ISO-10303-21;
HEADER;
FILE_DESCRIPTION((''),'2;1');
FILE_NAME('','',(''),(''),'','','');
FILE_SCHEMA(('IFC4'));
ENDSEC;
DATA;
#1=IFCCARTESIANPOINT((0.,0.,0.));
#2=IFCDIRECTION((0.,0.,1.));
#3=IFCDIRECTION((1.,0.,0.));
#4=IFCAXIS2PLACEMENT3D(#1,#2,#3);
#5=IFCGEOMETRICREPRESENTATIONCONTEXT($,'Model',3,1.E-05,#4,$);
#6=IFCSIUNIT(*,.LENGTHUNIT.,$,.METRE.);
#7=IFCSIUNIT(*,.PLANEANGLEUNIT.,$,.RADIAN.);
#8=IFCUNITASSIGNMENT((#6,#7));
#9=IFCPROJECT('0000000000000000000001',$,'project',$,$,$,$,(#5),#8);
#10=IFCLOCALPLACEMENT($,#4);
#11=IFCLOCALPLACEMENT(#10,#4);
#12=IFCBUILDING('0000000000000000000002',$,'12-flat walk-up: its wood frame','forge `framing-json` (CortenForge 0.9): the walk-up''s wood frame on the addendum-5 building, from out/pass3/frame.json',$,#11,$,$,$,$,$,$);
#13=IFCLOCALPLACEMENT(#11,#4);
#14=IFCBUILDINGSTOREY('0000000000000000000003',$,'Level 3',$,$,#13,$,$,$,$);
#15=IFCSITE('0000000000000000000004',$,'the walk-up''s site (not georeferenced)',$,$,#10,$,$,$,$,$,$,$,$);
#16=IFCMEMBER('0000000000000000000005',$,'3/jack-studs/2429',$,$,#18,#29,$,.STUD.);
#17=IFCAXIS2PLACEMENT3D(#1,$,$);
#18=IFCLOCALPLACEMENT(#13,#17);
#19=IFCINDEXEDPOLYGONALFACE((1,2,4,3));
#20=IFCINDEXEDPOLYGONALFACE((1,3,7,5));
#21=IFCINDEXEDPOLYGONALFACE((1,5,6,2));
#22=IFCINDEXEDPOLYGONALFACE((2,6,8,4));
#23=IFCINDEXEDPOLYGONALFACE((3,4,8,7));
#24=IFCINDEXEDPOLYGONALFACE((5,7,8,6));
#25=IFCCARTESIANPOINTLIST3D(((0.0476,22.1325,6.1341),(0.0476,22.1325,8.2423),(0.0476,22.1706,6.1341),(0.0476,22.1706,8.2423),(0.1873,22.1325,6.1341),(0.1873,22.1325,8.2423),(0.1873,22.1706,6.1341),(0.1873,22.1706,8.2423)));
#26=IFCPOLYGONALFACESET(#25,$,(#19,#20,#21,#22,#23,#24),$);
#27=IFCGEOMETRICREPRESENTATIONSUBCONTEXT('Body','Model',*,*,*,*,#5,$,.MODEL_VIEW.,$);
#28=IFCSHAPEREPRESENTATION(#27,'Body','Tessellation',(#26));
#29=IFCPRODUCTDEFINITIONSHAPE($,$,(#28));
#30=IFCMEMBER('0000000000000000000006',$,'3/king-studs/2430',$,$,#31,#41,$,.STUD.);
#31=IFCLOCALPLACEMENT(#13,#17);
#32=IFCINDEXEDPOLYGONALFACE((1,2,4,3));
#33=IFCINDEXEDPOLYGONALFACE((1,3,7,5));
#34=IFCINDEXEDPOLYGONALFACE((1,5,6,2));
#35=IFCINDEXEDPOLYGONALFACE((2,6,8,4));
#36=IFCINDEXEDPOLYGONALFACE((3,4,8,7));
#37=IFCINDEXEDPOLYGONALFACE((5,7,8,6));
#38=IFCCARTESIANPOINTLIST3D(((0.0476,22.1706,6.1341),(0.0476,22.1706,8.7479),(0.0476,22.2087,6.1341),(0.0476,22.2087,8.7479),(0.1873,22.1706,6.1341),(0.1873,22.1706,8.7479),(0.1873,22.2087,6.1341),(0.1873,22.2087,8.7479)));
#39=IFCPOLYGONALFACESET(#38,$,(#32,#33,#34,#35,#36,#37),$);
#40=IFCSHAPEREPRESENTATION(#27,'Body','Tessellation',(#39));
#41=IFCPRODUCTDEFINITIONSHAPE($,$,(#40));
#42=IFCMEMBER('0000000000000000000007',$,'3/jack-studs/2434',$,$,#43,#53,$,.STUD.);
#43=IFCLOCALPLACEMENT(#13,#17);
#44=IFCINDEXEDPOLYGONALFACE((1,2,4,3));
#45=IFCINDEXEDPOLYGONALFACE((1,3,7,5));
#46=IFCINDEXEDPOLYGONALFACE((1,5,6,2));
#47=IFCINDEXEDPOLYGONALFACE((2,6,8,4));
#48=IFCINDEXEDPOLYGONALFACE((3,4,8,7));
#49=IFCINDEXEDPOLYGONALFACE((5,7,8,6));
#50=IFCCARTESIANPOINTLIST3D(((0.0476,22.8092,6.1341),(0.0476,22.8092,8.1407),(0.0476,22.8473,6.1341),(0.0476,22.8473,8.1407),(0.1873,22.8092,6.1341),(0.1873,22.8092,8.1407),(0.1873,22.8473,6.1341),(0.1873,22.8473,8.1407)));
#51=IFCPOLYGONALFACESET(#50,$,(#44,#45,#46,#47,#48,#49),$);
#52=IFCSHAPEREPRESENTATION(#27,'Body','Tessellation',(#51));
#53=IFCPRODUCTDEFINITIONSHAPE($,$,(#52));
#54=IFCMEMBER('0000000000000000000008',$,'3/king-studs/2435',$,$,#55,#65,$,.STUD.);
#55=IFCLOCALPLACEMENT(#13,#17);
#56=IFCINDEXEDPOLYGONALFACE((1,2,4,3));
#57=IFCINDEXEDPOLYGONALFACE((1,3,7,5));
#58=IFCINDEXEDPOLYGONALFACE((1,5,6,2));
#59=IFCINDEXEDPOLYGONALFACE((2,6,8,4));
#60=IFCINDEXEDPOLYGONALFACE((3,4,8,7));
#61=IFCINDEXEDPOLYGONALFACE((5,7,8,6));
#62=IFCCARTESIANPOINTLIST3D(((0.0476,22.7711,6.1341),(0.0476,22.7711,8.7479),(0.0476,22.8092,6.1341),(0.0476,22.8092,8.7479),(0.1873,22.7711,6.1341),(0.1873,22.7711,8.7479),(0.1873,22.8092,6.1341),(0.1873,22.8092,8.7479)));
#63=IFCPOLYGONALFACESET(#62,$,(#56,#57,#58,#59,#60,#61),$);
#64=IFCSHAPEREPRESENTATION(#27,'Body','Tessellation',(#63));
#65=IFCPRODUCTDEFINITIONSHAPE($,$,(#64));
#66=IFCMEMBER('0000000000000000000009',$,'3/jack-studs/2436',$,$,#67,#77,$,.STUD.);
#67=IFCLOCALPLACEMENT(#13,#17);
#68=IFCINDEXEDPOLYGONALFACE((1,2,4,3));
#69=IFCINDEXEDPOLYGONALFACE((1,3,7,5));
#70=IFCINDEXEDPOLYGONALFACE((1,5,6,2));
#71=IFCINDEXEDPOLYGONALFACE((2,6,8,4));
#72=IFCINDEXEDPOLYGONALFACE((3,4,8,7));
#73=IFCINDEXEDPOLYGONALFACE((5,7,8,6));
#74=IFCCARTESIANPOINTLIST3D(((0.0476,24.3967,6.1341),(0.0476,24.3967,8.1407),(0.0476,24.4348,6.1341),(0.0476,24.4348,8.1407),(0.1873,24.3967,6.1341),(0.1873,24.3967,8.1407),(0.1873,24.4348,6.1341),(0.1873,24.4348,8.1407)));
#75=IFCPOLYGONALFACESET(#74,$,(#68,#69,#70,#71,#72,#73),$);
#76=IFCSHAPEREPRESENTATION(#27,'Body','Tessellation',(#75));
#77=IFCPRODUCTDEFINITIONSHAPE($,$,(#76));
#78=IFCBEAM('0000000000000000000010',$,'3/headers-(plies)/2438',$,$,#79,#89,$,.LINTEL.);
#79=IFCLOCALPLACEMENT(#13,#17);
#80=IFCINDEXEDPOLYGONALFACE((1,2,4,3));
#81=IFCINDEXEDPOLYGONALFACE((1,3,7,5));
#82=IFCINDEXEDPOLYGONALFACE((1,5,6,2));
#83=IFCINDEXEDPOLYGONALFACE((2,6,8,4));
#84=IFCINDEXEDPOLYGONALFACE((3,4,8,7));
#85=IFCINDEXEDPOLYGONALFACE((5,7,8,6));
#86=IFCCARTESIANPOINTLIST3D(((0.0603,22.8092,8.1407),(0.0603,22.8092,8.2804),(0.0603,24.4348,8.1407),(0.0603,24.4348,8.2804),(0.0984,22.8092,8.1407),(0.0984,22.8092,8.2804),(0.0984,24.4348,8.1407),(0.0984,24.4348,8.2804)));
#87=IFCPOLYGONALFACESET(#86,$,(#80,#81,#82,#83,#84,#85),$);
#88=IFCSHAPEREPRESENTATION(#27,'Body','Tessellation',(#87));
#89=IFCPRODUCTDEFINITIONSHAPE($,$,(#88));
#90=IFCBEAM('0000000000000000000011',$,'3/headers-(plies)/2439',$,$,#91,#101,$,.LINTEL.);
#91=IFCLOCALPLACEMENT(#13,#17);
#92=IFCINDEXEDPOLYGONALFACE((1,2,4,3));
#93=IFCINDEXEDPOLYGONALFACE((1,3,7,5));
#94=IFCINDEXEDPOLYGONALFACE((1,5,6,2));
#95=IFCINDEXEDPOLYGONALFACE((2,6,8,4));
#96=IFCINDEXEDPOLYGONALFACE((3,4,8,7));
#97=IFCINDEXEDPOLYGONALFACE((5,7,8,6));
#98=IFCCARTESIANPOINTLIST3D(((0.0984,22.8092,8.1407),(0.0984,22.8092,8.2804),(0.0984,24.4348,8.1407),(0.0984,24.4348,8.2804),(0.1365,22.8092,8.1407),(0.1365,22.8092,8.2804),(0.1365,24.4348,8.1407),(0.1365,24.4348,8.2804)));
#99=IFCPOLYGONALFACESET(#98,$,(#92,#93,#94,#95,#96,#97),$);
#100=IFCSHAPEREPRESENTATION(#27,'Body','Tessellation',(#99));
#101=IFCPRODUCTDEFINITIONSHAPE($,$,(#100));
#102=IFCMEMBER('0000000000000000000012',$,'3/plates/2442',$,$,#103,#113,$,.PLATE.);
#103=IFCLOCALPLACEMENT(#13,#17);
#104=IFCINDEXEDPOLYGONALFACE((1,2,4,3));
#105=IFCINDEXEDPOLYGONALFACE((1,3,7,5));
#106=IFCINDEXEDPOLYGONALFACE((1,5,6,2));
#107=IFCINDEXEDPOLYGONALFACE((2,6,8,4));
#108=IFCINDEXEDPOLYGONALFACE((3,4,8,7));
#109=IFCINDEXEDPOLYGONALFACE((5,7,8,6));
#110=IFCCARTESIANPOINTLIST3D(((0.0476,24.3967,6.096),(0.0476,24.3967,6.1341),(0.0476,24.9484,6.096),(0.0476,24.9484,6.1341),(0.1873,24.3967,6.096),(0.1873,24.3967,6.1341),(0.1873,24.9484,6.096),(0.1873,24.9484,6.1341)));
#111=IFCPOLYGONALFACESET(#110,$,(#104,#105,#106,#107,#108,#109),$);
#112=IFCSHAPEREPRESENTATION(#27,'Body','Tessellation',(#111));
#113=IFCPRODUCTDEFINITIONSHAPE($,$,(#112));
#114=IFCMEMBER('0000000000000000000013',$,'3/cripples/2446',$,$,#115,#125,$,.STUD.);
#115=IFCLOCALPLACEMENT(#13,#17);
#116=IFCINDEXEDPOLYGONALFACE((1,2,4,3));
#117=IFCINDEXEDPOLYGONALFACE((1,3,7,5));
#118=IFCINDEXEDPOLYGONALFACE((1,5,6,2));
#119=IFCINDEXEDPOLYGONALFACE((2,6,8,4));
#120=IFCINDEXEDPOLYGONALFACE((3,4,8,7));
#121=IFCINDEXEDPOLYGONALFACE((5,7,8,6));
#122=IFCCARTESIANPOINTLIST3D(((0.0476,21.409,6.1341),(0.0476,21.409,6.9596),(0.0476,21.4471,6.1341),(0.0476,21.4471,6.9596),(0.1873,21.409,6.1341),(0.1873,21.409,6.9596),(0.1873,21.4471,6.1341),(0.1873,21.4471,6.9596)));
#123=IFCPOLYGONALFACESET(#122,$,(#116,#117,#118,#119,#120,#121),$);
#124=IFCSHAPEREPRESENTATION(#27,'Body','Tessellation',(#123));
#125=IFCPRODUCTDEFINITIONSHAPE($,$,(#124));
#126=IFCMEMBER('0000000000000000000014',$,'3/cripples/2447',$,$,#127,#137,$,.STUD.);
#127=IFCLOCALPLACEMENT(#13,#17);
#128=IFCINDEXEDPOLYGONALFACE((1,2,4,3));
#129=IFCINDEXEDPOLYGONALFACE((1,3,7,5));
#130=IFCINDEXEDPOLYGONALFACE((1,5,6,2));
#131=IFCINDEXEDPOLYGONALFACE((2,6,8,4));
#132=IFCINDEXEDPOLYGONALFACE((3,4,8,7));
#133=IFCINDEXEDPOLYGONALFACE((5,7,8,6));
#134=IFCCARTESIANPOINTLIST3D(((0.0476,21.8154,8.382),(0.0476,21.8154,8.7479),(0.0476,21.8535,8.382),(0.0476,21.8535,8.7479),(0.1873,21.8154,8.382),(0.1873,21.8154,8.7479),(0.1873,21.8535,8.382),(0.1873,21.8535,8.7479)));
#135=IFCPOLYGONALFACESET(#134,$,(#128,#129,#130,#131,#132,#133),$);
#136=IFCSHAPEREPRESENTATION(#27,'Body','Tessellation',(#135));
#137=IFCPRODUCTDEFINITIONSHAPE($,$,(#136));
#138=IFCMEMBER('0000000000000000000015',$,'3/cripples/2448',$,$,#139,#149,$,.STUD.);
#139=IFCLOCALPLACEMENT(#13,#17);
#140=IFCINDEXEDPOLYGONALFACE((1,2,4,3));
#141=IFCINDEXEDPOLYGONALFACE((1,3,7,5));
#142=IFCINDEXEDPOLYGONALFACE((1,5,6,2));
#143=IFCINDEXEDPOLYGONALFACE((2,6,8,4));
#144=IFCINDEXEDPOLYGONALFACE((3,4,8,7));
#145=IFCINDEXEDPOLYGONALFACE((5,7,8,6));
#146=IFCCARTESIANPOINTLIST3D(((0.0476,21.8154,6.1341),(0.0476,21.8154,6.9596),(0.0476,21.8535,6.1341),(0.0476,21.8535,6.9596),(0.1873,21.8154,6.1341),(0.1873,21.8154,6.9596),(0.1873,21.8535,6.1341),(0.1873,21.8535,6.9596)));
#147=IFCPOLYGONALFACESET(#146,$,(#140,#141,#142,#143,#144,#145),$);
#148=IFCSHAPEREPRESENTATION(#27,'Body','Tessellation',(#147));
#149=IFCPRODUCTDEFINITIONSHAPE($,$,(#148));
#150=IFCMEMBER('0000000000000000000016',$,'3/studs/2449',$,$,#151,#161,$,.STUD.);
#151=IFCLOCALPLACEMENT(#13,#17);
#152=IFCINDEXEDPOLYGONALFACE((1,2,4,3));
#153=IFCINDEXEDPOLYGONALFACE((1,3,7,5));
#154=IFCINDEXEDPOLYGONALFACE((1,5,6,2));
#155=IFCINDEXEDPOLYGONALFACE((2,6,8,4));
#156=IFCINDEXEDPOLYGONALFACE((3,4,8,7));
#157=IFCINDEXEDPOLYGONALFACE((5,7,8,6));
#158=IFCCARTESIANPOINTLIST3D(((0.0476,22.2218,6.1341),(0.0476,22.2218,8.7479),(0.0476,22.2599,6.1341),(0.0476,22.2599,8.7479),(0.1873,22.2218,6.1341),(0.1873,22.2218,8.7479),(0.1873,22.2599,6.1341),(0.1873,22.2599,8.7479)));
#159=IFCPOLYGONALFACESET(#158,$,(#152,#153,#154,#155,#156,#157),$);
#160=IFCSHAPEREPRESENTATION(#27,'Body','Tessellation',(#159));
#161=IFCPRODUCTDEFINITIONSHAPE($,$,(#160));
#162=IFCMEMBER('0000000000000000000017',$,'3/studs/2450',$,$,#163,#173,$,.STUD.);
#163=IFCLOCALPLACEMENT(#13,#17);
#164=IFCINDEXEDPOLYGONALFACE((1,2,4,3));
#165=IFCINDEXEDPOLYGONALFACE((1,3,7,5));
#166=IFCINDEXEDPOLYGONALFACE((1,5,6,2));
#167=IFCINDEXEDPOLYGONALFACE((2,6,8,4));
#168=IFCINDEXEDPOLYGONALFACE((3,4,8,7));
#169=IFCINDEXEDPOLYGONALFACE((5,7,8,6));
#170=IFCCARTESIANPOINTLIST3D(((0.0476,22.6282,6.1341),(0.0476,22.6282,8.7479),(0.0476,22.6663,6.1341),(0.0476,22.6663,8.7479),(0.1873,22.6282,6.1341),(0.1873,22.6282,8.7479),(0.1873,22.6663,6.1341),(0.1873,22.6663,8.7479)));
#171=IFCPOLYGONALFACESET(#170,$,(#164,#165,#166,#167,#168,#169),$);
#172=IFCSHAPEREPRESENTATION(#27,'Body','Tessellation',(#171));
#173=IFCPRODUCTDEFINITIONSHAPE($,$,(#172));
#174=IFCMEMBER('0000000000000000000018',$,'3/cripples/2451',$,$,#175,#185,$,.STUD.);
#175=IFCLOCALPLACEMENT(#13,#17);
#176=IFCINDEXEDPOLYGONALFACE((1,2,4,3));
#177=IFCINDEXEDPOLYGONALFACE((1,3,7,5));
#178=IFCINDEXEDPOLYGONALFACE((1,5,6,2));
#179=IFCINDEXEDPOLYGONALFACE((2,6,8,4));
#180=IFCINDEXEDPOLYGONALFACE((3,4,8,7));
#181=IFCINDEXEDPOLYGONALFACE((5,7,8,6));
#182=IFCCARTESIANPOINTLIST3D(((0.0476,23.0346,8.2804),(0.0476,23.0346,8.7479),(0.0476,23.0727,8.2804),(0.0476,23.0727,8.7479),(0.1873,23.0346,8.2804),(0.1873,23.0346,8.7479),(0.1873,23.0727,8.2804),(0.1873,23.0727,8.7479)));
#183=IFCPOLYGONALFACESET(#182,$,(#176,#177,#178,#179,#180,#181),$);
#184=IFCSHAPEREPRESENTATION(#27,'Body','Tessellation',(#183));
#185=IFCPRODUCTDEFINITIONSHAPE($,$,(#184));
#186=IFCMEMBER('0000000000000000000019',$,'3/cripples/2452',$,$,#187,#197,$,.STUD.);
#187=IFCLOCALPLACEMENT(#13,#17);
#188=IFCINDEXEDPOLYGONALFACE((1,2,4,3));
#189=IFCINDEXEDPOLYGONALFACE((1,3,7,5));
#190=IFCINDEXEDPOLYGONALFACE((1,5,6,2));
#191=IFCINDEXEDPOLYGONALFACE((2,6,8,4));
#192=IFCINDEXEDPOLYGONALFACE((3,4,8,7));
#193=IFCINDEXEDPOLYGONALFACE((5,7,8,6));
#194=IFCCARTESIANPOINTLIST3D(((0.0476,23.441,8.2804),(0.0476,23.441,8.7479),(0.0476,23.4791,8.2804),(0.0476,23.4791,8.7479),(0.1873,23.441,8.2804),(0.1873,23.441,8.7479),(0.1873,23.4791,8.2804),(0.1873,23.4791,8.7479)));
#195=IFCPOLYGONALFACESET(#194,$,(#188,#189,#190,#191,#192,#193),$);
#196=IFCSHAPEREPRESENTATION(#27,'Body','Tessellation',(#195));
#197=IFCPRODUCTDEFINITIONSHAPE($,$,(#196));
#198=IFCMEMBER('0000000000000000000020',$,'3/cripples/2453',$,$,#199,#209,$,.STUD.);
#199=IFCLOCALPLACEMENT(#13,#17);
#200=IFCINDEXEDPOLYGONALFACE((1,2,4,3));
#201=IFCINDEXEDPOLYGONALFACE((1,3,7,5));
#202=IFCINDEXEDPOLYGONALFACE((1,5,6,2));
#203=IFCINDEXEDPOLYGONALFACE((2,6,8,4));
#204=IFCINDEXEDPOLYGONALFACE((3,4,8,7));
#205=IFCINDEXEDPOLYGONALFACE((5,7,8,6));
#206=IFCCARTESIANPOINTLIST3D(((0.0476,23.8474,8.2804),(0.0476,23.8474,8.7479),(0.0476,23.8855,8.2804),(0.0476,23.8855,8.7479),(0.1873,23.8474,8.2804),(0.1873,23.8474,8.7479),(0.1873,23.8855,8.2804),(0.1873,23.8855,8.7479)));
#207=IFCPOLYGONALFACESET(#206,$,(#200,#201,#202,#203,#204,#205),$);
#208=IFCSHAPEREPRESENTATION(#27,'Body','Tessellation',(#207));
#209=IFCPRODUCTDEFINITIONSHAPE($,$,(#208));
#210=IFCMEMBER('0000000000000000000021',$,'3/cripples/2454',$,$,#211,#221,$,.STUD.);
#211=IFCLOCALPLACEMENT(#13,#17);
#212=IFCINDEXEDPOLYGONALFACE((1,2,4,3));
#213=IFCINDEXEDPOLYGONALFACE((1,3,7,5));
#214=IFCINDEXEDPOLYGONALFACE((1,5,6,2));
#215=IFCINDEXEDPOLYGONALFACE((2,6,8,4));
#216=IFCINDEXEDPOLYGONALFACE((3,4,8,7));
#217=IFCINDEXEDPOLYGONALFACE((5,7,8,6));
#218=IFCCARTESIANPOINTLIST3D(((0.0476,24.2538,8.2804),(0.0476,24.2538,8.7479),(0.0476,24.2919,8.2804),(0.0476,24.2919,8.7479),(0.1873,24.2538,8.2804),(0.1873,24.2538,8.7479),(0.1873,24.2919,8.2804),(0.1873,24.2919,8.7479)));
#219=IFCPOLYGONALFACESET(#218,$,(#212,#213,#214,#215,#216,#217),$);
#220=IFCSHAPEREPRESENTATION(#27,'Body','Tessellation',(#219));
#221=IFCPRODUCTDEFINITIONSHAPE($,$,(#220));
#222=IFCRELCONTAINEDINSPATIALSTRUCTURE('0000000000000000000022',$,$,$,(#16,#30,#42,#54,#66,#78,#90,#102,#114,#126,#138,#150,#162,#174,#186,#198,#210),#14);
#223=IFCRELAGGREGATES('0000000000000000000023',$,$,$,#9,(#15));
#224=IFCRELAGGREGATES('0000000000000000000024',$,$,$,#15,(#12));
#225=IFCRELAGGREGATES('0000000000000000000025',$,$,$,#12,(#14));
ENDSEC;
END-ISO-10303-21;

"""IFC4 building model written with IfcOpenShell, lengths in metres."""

from ifc_helpers import new_model, si_unit, frame, frame_2d, origin, origin_with_axes, place, context, subcontext, project, spatial, rectangle, extrude, element, save


model = new_model("IFC4")

# Units and contexts
model_context = context("Model", 3, precision=1e-05, world=origin_with_axes())
body_context = subcontext(model_context, "Body", "Model", "MODEL_VIEW")
ifc_project = project(units=[si_unit("LENGTHUNIT", "METRE"), si_unit("PLANEANGLEUNIT", "RADIAN")], contexts=[model_context])

# Site, building, storey
site_placement = place(None, origin_with_axes())
site = spatial("IfcSite", under=ifc_project, at=site_placement, Name="the walk-up's site (not georeferenced)")
building_placement = place(site_placement, origin_with_axes())
building = spatial("IfcBuilding", under=site, at=building_placement, Name="12-flat walk-up: its wood frame", Description="forge `framing-json` (CortenForge 0.9): the walk-up's wood frame on the addendum-5 building, from out/pass3/frame.json")
storey_placement = place(building_placement, origin_with_axes())
storey = spatial("IfcBuildingStorey", under=building, at=storey_placement, Name="Level 3")

# Members
member_1_placement = place(storey_placement, frame((0.0476, 22.1325, 6.1341), z_axis=(0.0, 0.0, 1.0), x_axis=(1.0, 0.0, 0.0)))
element("IfcMember", 1, at=member_1_placement, inside=storey, Name="3/jack-studs/2429", PredefinedType="STUD", context=body_context, shape_type="SweptSolid", body=[
    extrude(rectangle(XDim=0.1397, YDim=0.0381, at=frame_2d((0.0698, 0.0191))), origin(), (0.0, 0.0, 1.0), 2.1082),
])
member_2_placement = place(storey_placement, frame((0.0476, 22.1706, 6.1341), z_axis=(0.0, 0.0, 1.0), x_axis=(1.0, 0.0, 0.0)))
element("IfcMember", 2, at=member_2_placement, inside=storey, Name="3/king-studs/2430", PredefinedType="STUD", context=body_context, shape_type="SweptSolid", body=[
    extrude(rectangle(XDim=0.1397, YDim=0.0381, at=frame_2d((0.0698, 0.0191))), origin(), (0.0, 0.0, 1.0), 2.6138),
])
member_3_placement = place(storey_placement, frame((0.0476, 22.8092, 6.1341), z_axis=(0.0, 0.0, 1.0), x_axis=(1.0, 0.0, 0.0)))
element("IfcMember", 3, at=member_3_placement, inside=storey, Name="3/jack-studs/2434", PredefinedType="STUD", context=body_context, shape_type="SweptSolid", body=[
    extrude(rectangle(XDim=0.1397, YDim=0.0381, at=frame_2d((0.0698, 0.0191))), origin(), (0.0, 0.0, 1.0), 2.0066),
])
member_4_placement = place(storey_placement, frame((0.0476, 22.7711, 6.1341), z_axis=(0.0, 0.0, 1.0), x_axis=(1.0, 0.0, 0.0)))
element("IfcMember", 4, at=member_4_placement, inside=storey, Name="3/king-studs/2435", PredefinedType="STUD", context=body_context, shape_type="SweptSolid", body=[
    extrude(rectangle(XDim=0.1397, YDim=0.0381, at=frame_2d((0.0698, 0.0191))), origin(), (0.0, 0.0, 1.0), 2.6138),
])
member_5_placement = place(storey_placement, frame((0.0476, 24.3967, 6.1341), z_axis=(0.0, 0.0, 1.0), x_axis=(1.0, 0.0, 0.0)))
element("IfcMember", 5, at=member_5_placement, inside=storey, Name="3/jack-studs/2436", PredefinedType="STUD", context=body_context, shape_type="SweptSolid", body=[
    extrude(rectangle(XDim=0.1397, YDim=0.0381, at=frame_2d((0.0698, 0.0191))), origin(), (0.0, 0.0, 1.0), 2.0066),
])

# Beams
beam_1_placement = place(storey_placement, frame((0.0603, 22.8092, 8.1407), z_axis=(0.0, 0.0, 1.0), x_axis=(1.0, 0.0, 0.0)))
element("IfcBeam", 6, at=beam_1_placement, inside=storey, Name="3/headers-(plies)/2438", PredefinedType="LINTEL", context=body_context, shape_type="SweptSolid", body=[
    extrude(rectangle(XDim=0.0381, YDim=1.6256, at=frame_2d((0.0191, 0.8128))), origin(), (0.0, 0.0, 1.0), 0.1397),
])
beam_2_placement = place(storey_placement, frame((0.0984, 22.8092, 8.1407), z_axis=(0.0, 0.0, 1.0), x_axis=(1.0, 0.0, 0.0)))
element("IfcBeam", 7, at=beam_2_placement, inside=storey, Name="3/headers-(plies)/2439", PredefinedType="LINTEL", context=body_context, shape_type="SweptSolid", body=[
    extrude(rectangle(XDim=0.0381, YDim=1.6256, at=frame_2d((0.0191, 0.8128))), origin(), (0.0, 0.0, 1.0), 0.1397),
])

# Members
member_6_placement = place(storey_placement, frame((0.0476, 24.3967, 6.096), z_axis=(0.0, 0.0, 1.0), x_axis=(1.0, 0.0, 0.0)))
element("IfcMember", 8, at=member_6_placement, inside=storey, Name="3/plates/2442", PredefinedType="PLATE", context=body_context, shape_type="SweptSolid", body=[
    extrude(rectangle(XDim=0.1397, YDim=0.5517, at=frame_2d((0.0698, 0.2759))), origin(), (0.0, 0.0, 1.0), 0.0381),
])
member_7_placement = place(storey_placement, frame((0.0476, 21.409, 6.1341), z_axis=(0.0, 0.0, 1.0), x_axis=(1.0, 0.0, 0.0)))
element("IfcMember", 9, at=member_7_placement, inside=storey, Name="3/cripples/2446", PredefinedType="STUD", context=body_context, shape_type="SweptSolid", body=[
    extrude(rectangle(XDim=0.1397, YDim=0.0381, at=frame_2d((0.0698, 0.0191))), origin(), (0.0, 0.0, 1.0), 0.8255),
])
member_8_placement = place(storey_placement, frame((0.0476, 21.8154, 8.382), z_axis=(0.0, 0.0, 1.0), x_axis=(1.0, 0.0, 0.0)))
element("IfcMember", 10, at=member_8_placement, inside=storey, Name="3/cripples/2447", PredefinedType="STUD", context=body_context, shape_type="SweptSolid", body=[
    extrude(rectangle(XDim=0.1397, YDim=0.0381, at=frame_2d((0.0698, 0.0191))), origin(), (0.0, 0.0, 1.0), 0.3659),
])
member_9_placement = place(storey_placement, frame((0.0476, 21.8154, 6.1341), z_axis=(0.0, 0.0, 1.0), x_axis=(1.0, 0.0, 0.0)))
element("IfcMember", 11, at=member_9_placement, inside=storey, Name="3/cripples/2448", PredefinedType="STUD", context=body_context, shape_type="SweptSolid", body=[
    extrude(rectangle(XDim=0.1397, YDim=0.0381, at=frame_2d((0.0698, 0.0191))), origin(), (0.0, 0.0, 1.0), 0.8255),
])
for number, where, z_axis, x_axis, name in (
    (12, (0.0476, 22.2218, 6.1341), (0.0, 0.0, 1.0), (1.0, 0.0, 0.0), "3/studs/2449"),
    (13, (0.0476, 22.6282, 6.1341), (0.0, 0.0, 1.0), (1.0, 0.0, 0.0), "3/studs/2450"),
):
    element("IfcMember", number, at=place(storey_placement, frame(where, z_axis=z_axis, x_axis=x_axis)), inside=storey, Name=name, PredefinedType="STUD", context=body_context, shape_type="SweptSolid", body=[
        extrude(rectangle(XDim=0.1397, YDim=0.0381, at=frame_2d((0.0698, 0.0191))), origin(), (0.0, 0.0, 1.0), 2.6138),
    ])
for number, where, z_axis, x_axis, name in (
    (14, (0.0476, 23.0346, 8.2804), (0.0, 0.0, 1.0), (1.0, 0.0, 0.0), "3/cripples/2451"),
    (15, (0.0476, 23.441, 8.2804), (0.0, 0.0, 1.0), (1.0, 0.0, 0.0), "3/cripples/2452"),
    (16, (0.0476, 23.8474, 8.2804), (0.0, 0.0, 1.0), (1.0, 0.0, 0.0), "3/cripples/2453"),
    (17, (0.0476, 24.2538, 8.2804), (0.0, 0.0, 1.0), (1.0, 0.0, 0.0), "3/cripples/2454"),
):
    element("IfcMember", number, at=place(storey_placement, frame(where, z_axis=z_axis, x_axis=x_axis)), inside=storey, Name=name, PredefinedType="STUD", context=body_context, shape_type="SweptSolid", body=[
        extrude(rectangle(XDim=0.1397, YDim=0.0381, at=frame_2d((0.0698, 0.0191))), origin(), (0.0, 0.0, 1.0), 0.4675),
    ])

save(model, "model.ifc")
